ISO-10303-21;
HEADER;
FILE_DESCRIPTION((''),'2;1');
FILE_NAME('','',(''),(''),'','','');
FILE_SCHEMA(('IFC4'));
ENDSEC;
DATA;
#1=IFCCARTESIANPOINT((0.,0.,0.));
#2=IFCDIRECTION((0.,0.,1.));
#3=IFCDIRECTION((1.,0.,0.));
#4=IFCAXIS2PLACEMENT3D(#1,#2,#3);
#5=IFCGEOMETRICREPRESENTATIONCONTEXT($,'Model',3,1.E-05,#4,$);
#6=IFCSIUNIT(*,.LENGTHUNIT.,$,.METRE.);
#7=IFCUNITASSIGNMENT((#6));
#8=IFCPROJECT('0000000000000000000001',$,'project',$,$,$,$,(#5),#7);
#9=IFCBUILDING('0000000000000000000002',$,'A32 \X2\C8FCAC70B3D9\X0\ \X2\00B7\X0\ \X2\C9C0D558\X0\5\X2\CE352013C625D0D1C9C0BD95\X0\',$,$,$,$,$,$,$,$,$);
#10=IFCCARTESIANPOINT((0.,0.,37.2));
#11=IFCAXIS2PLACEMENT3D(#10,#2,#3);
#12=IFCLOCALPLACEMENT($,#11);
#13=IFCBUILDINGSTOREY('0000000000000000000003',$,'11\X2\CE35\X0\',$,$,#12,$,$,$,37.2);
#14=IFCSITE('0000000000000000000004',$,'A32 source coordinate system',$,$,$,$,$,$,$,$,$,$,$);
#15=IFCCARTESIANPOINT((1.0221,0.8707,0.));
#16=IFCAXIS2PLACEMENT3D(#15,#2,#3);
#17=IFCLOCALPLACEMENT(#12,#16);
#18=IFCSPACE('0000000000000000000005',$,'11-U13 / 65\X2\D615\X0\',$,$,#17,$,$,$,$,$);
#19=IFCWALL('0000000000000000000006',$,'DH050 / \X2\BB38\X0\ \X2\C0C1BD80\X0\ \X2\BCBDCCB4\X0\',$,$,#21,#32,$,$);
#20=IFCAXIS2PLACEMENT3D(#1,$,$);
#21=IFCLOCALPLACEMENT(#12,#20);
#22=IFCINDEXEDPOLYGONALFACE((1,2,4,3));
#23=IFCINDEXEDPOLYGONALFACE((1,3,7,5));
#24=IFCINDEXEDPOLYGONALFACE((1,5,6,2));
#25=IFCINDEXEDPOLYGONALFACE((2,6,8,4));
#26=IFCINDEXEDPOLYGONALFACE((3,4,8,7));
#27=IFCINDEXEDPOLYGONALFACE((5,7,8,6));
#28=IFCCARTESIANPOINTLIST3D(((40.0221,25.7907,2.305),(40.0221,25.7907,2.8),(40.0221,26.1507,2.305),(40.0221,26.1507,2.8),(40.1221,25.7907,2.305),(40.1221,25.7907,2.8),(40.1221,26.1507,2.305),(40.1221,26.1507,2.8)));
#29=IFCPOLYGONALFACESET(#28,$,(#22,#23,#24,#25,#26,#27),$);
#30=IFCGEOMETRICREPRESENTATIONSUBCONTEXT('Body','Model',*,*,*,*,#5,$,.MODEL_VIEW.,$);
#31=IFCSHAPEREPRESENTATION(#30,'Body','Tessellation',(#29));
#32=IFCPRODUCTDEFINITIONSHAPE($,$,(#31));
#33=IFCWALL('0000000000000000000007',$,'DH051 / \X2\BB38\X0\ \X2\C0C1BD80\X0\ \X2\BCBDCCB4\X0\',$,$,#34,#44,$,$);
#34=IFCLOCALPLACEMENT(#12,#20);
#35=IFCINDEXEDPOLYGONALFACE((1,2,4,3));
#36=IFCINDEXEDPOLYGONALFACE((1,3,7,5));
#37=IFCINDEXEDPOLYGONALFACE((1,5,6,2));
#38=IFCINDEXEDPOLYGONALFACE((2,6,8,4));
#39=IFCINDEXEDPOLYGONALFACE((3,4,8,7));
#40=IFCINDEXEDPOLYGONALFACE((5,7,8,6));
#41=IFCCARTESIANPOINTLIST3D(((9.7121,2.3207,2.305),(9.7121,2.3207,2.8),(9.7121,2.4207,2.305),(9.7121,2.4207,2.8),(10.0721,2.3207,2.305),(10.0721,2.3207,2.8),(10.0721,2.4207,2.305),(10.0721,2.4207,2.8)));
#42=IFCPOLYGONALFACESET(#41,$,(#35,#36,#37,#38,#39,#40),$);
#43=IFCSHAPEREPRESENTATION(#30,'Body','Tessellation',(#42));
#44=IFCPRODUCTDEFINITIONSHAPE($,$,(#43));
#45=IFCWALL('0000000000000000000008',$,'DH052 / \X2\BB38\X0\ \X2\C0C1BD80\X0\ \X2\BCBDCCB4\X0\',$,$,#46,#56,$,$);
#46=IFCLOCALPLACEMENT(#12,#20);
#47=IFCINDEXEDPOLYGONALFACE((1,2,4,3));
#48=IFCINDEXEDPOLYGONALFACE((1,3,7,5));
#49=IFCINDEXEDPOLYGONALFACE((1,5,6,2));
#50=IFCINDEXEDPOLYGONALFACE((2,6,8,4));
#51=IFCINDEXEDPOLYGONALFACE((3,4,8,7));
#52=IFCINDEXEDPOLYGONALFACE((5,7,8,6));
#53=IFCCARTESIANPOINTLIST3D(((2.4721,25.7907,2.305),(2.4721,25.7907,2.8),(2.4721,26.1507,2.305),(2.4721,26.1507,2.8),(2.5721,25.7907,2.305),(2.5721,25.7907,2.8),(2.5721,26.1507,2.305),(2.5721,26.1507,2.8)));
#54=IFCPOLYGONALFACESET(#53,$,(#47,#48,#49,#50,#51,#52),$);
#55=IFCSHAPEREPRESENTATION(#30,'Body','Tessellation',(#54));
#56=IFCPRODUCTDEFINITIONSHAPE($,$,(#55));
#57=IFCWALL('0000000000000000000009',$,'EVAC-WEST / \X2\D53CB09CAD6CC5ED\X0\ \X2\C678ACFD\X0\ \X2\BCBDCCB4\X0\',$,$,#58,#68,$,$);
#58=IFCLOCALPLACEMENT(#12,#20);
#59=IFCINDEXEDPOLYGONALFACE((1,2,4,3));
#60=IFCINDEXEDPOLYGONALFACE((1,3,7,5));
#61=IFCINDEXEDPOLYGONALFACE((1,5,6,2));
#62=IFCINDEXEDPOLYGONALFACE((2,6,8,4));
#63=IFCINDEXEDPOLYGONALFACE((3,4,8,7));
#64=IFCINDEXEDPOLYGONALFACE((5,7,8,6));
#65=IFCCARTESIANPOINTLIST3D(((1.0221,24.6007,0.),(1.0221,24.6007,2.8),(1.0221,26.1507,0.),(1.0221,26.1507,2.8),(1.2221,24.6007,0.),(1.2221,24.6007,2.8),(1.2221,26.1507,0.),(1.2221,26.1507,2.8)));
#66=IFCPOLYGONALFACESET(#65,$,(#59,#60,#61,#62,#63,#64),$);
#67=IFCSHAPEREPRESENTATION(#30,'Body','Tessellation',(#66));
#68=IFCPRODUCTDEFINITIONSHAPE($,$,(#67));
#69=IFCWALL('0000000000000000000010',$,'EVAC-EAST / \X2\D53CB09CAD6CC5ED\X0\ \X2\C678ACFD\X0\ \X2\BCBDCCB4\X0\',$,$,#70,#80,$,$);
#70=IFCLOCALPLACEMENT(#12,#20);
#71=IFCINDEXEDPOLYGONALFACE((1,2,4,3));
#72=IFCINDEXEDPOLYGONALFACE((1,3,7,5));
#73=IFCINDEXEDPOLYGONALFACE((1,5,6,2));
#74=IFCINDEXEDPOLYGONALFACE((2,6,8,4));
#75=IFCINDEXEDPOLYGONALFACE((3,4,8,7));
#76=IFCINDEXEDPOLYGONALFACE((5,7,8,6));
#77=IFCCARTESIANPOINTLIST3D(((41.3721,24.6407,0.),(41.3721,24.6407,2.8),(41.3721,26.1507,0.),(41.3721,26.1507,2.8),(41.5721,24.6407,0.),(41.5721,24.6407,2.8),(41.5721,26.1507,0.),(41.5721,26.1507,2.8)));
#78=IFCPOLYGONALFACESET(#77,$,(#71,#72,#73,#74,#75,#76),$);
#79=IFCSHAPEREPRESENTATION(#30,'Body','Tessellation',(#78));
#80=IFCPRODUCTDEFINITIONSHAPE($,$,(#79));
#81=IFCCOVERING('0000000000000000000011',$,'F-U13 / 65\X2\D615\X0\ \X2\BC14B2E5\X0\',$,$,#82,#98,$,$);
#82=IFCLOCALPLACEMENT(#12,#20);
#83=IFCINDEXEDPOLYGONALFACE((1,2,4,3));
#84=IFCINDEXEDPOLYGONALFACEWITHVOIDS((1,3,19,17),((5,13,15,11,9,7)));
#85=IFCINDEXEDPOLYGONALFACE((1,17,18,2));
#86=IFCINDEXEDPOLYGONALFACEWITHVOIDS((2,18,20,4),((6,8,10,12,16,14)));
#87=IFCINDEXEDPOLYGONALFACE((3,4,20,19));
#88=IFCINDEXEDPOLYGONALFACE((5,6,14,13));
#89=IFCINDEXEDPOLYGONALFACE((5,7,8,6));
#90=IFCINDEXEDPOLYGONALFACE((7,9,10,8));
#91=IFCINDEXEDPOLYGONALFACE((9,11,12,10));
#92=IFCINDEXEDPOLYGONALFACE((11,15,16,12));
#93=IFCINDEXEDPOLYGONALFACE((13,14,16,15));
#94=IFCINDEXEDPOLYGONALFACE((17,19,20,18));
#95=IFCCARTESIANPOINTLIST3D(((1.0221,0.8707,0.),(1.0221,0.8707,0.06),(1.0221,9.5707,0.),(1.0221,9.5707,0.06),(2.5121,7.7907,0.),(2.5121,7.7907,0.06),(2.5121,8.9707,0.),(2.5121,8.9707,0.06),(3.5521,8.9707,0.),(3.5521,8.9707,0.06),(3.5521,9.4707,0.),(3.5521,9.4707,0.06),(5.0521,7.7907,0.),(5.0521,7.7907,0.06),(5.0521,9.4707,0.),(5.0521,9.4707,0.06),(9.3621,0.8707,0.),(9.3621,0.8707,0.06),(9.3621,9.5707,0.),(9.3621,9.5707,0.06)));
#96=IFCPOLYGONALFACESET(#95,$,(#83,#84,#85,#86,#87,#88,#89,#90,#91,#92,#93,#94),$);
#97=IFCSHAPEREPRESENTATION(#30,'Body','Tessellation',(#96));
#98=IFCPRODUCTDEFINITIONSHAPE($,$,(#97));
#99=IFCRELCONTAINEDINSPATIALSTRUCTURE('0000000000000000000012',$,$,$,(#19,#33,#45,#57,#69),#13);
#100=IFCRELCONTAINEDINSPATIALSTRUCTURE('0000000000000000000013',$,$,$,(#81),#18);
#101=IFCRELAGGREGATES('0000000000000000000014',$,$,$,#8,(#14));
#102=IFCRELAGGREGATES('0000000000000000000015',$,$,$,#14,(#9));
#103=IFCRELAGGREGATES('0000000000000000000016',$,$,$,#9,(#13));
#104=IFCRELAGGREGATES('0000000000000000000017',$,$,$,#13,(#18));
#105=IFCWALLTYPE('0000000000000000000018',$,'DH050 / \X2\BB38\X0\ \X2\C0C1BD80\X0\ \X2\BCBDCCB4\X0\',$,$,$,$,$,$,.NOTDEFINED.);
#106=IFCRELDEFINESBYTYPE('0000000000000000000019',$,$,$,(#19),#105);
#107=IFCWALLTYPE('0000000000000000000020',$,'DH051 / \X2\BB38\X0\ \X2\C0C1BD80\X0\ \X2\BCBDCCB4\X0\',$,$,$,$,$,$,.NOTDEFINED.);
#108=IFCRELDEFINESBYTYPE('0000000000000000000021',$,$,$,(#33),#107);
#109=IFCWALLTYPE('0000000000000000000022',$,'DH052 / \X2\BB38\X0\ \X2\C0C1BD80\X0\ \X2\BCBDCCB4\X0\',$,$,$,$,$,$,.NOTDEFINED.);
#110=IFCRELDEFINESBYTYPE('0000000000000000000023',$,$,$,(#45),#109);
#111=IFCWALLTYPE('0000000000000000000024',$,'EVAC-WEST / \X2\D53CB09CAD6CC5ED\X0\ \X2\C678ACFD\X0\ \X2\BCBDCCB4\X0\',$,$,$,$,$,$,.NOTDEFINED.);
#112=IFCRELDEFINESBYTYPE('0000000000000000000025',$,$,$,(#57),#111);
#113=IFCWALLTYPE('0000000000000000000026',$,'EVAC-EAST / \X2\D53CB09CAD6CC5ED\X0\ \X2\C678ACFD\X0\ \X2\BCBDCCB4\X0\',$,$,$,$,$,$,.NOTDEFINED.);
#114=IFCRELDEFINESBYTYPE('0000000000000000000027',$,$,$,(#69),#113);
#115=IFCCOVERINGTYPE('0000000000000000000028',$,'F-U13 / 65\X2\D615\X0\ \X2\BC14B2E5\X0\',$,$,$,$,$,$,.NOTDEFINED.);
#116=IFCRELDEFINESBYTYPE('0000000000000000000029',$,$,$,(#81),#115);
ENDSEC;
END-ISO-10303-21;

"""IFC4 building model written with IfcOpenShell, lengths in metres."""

from ifc_helpers import new_model, si_unit, frame, origin, origin_with_axes, place, context, subcontext, project, spatial, polyline, outline, extrude, source, transform, mapped, type_object, type_shapes, element, save


model = new_model("IFC4")

# Units and contexts
model_context = context("Model", 3, precision=1e-05, world=origin_with_axes())
body_context = subcontext(model_context, "Body", "Model", "MODEL_VIEW")
ifc_project = project(units=[si_unit("LENGTHUNIT", "METRE")], contexts=[model_context])

# Site, building, storey
site = spatial("IfcSite", under=ifc_project, Name="A32 source coordinate system")
building = spatial("IfcBuilding", under=site, Name="A32 주거동 · 지하5층–옥탑지붕")
storey_placement = place(None, frame((0.0, 0.0, 37.2), z_axis=(0.0, 0.0, 1.0), x_axis=(1.0, 0.0, 0.0)))
storey = spatial("IfcBuildingStorey", under=building, at=storey_placement, Name="11층", Elevation=37.2)

# Walls
wall_type_1 = type_object("IfcWallType", Name="DH050 / 문 상부 벽체", PredefinedType="NOTDEFINED")
shared_shape_1 = source(origin(), body_context, "Body", "SweptSolid", [
    extrude(outline(polyline([(40.0221, 25.7907), (40.0221, 26.1507), (40.1221, 26.1507), (40.1221, 25.7907), (40.0221, 25.7907)])), frame((0.0, 0.0, 2.305)), (0.0, 0.0, 1.0), 0.495),
])
type_shapes(wall_type_1, [shared_shape_1])
wall_1_placement = place(storey_placement, origin_with_axes())
element("IfcWall", 1, at=wall_1_placement, inside=storey, type_object=wall_type_1, Name="DH050 / 문 상부 벽체", context=body_context, shape_type="MappedRepresentation", body=[
    mapped(shared_shape_1, transform((0.0, 0.0, 0.0), scale=1.0)),
])
wall_type_2 = type_object("IfcWallType", Name="DH051 / 문 상부 벽체", PredefinedType="NOTDEFINED")
shared_shape_2 = source(origin(), body_context, "Body", "SweptSolid", [
    extrude(outline(polyline([(10.0721, 2.3207), (9.7121, 2.3207), (9.7121, 2.4207), (10.0721, 2.4207), (10.0721, 2.3207)])), frame((0.0, 0.0, 2.305)), (0.0, 0.0, 1.0), 0.495),
])
type_shapes(wall_type_2, [shared_shape_2])
wall_2_placement = place(storey_placement, origin_with_axes())
element("IfcWall", 2, at=wall_2_placement, inside=storey, type_object=wall_type_2, Name="DH051 / 문 상부 벽체", context=body_context, shape_type="MappedRepresentation", body=[
    mapped(shared_shape_2, transform((0.0, 0.0, 0.0), scale=1.0)),
])
wall_type_3 = type_object("IfcWallType", Name="DH052 / 문 상부 벽체", PredefinedType="NOTDEFINED")
shared_shape_3 = source(origin(), body_context, "Body", "SweptSolid", [
    extrude(outline(polyline([(2.5721, 25.7907), (2.4721, 25.7907), (2.4721, 26.1507), (2.5721, 26.1507), (2.5721, 25.7907)])), frame((0.0, 0.0, 2.305)), (0.0, 0.0, 1.0), 0.495),
])
type_shapes(wall_type_3, [shared_shape_3])
wall_3_placement = place(storey_placement, origin_with_axes())
element("IfcWall", 3, at=wall_3_placement, inside=storey, type_object=wall_type_3, Name="DH052 / 문 상부 벽체", context=body_context, shape_type="MappedRepresentation", body=[
    mapped(shared_shape_3, transform((0.0, 0.0, 0.0), scale=1.0)),
])
wall_type_4 = type_object("IfcWallType", Name="EVAC-WEST / 피난구역 외곽 벽체", PredefinedType="NOTDEFINED")
shared_shape_4 = source(origin(), body_context, "Body", "SweptSolid", [
    extrude(outline(polyline([(1.2221, 24.6007), (1.0221, 24.6007), (1.0221, 26.1507), (1.2221, 26.1507), (1.2221, 24.6007)])), origin(), (0.0, 0.0, 1.0), 2.8),
])
type_shapes(wall_type_4, [shared_shape_4])
wall_4_placement = place(storey_placement, origin_with_axes())
element("IfcWall", 4, at=wall_4_placement, inside=storey, type_object=wall_type_4, Name="EVAC-WEST / 피난구역 외곽 벽체", context=body_context, shape_type="MappedRepresentation", body=[
    mapped(shared_shape_4, transform((0.0, 0.0, 0.0), scale=1.0)),
])
wall_type_5 = type_object("IfcWallType", Name="EVAC-EAST / 피난구역 외곽 벽체", PredefinedType="NOTDEFINED")
shared_shape_5 = source(origin(), body_context, "Body", "SweptSolid", [
    extrude(outline(polyline([(41.5721, 26.1507), (41.5721, 24.6407), (41.3721, 24.6407), (41.3721, 26.1507), (41.5721, 26.1507)])), origin(), (0.0, 0.0, 1.0), 2.8),
])
type_shapes(wall_type_5, [shared_shape_5])
wall_5_placement = place(storey_placement, origin_with_axes())
element("IfcWall", 5, at=wall_5_placement, inside=storey, type_object=wall_type_5, Name="EVAC-EAST / 피난구역 외곽 벽체", context=body_context, shape_type="MappedRepresentation", body=[
    mapped(shared_shape_5, transform((0.0, 0.0, 0.0), scale=1.0)),
])

# Shared definitions
space_placement = place(storey_placement, frame((1.0221, 0.8707, 0.0), z_axis=(0.0, 0.0, 1.0), x_axis=(1.0, 0.0, 0.0)))
space = spatial("IfcSpace", under=storey, at=space_placement, Name="11-U13 / 65형")

# Covering
covering_type_1 = type_object("IfcCoveringType", Name="F-U13 / 65형 바닥", PredefinedType="NOTDEFINED")
shared_shape_6 = source(origin(), body_context, "Body", "SweptSolid", [
    extrude(outline(polyline([(0.0, 0.0), (0.0, 8.7), (8.34, 8.7), (8.34, 0.0), (0.0, 0.0)]), holes=[polyline([(2.53, 8.1), (1.49, 8.1), (1.49, 6.92), (4.03, 6.92), (4.03, 8.6), (2.53, 8.6), (2.53, 8.1)])]), origin(), (0.0, 0.0, 1.0), 0.06),
])
type_shapes(covering_type_1, [shared_shape_6])
covering_1_placement = place(space_placement, origin_with_axes())
element("IfcCovering", 6, at=covering_1_placement, inside=space, type_object=covering_type_1, Name="F-U13 / 65형 바닥", context=body_context, shape_type="MappedRepresentation", body=[
    mapped(shared_shape_6, transform((0.0, 0.0, 0.0), scale=1.0)),
])

save(model, "model.ifc")
